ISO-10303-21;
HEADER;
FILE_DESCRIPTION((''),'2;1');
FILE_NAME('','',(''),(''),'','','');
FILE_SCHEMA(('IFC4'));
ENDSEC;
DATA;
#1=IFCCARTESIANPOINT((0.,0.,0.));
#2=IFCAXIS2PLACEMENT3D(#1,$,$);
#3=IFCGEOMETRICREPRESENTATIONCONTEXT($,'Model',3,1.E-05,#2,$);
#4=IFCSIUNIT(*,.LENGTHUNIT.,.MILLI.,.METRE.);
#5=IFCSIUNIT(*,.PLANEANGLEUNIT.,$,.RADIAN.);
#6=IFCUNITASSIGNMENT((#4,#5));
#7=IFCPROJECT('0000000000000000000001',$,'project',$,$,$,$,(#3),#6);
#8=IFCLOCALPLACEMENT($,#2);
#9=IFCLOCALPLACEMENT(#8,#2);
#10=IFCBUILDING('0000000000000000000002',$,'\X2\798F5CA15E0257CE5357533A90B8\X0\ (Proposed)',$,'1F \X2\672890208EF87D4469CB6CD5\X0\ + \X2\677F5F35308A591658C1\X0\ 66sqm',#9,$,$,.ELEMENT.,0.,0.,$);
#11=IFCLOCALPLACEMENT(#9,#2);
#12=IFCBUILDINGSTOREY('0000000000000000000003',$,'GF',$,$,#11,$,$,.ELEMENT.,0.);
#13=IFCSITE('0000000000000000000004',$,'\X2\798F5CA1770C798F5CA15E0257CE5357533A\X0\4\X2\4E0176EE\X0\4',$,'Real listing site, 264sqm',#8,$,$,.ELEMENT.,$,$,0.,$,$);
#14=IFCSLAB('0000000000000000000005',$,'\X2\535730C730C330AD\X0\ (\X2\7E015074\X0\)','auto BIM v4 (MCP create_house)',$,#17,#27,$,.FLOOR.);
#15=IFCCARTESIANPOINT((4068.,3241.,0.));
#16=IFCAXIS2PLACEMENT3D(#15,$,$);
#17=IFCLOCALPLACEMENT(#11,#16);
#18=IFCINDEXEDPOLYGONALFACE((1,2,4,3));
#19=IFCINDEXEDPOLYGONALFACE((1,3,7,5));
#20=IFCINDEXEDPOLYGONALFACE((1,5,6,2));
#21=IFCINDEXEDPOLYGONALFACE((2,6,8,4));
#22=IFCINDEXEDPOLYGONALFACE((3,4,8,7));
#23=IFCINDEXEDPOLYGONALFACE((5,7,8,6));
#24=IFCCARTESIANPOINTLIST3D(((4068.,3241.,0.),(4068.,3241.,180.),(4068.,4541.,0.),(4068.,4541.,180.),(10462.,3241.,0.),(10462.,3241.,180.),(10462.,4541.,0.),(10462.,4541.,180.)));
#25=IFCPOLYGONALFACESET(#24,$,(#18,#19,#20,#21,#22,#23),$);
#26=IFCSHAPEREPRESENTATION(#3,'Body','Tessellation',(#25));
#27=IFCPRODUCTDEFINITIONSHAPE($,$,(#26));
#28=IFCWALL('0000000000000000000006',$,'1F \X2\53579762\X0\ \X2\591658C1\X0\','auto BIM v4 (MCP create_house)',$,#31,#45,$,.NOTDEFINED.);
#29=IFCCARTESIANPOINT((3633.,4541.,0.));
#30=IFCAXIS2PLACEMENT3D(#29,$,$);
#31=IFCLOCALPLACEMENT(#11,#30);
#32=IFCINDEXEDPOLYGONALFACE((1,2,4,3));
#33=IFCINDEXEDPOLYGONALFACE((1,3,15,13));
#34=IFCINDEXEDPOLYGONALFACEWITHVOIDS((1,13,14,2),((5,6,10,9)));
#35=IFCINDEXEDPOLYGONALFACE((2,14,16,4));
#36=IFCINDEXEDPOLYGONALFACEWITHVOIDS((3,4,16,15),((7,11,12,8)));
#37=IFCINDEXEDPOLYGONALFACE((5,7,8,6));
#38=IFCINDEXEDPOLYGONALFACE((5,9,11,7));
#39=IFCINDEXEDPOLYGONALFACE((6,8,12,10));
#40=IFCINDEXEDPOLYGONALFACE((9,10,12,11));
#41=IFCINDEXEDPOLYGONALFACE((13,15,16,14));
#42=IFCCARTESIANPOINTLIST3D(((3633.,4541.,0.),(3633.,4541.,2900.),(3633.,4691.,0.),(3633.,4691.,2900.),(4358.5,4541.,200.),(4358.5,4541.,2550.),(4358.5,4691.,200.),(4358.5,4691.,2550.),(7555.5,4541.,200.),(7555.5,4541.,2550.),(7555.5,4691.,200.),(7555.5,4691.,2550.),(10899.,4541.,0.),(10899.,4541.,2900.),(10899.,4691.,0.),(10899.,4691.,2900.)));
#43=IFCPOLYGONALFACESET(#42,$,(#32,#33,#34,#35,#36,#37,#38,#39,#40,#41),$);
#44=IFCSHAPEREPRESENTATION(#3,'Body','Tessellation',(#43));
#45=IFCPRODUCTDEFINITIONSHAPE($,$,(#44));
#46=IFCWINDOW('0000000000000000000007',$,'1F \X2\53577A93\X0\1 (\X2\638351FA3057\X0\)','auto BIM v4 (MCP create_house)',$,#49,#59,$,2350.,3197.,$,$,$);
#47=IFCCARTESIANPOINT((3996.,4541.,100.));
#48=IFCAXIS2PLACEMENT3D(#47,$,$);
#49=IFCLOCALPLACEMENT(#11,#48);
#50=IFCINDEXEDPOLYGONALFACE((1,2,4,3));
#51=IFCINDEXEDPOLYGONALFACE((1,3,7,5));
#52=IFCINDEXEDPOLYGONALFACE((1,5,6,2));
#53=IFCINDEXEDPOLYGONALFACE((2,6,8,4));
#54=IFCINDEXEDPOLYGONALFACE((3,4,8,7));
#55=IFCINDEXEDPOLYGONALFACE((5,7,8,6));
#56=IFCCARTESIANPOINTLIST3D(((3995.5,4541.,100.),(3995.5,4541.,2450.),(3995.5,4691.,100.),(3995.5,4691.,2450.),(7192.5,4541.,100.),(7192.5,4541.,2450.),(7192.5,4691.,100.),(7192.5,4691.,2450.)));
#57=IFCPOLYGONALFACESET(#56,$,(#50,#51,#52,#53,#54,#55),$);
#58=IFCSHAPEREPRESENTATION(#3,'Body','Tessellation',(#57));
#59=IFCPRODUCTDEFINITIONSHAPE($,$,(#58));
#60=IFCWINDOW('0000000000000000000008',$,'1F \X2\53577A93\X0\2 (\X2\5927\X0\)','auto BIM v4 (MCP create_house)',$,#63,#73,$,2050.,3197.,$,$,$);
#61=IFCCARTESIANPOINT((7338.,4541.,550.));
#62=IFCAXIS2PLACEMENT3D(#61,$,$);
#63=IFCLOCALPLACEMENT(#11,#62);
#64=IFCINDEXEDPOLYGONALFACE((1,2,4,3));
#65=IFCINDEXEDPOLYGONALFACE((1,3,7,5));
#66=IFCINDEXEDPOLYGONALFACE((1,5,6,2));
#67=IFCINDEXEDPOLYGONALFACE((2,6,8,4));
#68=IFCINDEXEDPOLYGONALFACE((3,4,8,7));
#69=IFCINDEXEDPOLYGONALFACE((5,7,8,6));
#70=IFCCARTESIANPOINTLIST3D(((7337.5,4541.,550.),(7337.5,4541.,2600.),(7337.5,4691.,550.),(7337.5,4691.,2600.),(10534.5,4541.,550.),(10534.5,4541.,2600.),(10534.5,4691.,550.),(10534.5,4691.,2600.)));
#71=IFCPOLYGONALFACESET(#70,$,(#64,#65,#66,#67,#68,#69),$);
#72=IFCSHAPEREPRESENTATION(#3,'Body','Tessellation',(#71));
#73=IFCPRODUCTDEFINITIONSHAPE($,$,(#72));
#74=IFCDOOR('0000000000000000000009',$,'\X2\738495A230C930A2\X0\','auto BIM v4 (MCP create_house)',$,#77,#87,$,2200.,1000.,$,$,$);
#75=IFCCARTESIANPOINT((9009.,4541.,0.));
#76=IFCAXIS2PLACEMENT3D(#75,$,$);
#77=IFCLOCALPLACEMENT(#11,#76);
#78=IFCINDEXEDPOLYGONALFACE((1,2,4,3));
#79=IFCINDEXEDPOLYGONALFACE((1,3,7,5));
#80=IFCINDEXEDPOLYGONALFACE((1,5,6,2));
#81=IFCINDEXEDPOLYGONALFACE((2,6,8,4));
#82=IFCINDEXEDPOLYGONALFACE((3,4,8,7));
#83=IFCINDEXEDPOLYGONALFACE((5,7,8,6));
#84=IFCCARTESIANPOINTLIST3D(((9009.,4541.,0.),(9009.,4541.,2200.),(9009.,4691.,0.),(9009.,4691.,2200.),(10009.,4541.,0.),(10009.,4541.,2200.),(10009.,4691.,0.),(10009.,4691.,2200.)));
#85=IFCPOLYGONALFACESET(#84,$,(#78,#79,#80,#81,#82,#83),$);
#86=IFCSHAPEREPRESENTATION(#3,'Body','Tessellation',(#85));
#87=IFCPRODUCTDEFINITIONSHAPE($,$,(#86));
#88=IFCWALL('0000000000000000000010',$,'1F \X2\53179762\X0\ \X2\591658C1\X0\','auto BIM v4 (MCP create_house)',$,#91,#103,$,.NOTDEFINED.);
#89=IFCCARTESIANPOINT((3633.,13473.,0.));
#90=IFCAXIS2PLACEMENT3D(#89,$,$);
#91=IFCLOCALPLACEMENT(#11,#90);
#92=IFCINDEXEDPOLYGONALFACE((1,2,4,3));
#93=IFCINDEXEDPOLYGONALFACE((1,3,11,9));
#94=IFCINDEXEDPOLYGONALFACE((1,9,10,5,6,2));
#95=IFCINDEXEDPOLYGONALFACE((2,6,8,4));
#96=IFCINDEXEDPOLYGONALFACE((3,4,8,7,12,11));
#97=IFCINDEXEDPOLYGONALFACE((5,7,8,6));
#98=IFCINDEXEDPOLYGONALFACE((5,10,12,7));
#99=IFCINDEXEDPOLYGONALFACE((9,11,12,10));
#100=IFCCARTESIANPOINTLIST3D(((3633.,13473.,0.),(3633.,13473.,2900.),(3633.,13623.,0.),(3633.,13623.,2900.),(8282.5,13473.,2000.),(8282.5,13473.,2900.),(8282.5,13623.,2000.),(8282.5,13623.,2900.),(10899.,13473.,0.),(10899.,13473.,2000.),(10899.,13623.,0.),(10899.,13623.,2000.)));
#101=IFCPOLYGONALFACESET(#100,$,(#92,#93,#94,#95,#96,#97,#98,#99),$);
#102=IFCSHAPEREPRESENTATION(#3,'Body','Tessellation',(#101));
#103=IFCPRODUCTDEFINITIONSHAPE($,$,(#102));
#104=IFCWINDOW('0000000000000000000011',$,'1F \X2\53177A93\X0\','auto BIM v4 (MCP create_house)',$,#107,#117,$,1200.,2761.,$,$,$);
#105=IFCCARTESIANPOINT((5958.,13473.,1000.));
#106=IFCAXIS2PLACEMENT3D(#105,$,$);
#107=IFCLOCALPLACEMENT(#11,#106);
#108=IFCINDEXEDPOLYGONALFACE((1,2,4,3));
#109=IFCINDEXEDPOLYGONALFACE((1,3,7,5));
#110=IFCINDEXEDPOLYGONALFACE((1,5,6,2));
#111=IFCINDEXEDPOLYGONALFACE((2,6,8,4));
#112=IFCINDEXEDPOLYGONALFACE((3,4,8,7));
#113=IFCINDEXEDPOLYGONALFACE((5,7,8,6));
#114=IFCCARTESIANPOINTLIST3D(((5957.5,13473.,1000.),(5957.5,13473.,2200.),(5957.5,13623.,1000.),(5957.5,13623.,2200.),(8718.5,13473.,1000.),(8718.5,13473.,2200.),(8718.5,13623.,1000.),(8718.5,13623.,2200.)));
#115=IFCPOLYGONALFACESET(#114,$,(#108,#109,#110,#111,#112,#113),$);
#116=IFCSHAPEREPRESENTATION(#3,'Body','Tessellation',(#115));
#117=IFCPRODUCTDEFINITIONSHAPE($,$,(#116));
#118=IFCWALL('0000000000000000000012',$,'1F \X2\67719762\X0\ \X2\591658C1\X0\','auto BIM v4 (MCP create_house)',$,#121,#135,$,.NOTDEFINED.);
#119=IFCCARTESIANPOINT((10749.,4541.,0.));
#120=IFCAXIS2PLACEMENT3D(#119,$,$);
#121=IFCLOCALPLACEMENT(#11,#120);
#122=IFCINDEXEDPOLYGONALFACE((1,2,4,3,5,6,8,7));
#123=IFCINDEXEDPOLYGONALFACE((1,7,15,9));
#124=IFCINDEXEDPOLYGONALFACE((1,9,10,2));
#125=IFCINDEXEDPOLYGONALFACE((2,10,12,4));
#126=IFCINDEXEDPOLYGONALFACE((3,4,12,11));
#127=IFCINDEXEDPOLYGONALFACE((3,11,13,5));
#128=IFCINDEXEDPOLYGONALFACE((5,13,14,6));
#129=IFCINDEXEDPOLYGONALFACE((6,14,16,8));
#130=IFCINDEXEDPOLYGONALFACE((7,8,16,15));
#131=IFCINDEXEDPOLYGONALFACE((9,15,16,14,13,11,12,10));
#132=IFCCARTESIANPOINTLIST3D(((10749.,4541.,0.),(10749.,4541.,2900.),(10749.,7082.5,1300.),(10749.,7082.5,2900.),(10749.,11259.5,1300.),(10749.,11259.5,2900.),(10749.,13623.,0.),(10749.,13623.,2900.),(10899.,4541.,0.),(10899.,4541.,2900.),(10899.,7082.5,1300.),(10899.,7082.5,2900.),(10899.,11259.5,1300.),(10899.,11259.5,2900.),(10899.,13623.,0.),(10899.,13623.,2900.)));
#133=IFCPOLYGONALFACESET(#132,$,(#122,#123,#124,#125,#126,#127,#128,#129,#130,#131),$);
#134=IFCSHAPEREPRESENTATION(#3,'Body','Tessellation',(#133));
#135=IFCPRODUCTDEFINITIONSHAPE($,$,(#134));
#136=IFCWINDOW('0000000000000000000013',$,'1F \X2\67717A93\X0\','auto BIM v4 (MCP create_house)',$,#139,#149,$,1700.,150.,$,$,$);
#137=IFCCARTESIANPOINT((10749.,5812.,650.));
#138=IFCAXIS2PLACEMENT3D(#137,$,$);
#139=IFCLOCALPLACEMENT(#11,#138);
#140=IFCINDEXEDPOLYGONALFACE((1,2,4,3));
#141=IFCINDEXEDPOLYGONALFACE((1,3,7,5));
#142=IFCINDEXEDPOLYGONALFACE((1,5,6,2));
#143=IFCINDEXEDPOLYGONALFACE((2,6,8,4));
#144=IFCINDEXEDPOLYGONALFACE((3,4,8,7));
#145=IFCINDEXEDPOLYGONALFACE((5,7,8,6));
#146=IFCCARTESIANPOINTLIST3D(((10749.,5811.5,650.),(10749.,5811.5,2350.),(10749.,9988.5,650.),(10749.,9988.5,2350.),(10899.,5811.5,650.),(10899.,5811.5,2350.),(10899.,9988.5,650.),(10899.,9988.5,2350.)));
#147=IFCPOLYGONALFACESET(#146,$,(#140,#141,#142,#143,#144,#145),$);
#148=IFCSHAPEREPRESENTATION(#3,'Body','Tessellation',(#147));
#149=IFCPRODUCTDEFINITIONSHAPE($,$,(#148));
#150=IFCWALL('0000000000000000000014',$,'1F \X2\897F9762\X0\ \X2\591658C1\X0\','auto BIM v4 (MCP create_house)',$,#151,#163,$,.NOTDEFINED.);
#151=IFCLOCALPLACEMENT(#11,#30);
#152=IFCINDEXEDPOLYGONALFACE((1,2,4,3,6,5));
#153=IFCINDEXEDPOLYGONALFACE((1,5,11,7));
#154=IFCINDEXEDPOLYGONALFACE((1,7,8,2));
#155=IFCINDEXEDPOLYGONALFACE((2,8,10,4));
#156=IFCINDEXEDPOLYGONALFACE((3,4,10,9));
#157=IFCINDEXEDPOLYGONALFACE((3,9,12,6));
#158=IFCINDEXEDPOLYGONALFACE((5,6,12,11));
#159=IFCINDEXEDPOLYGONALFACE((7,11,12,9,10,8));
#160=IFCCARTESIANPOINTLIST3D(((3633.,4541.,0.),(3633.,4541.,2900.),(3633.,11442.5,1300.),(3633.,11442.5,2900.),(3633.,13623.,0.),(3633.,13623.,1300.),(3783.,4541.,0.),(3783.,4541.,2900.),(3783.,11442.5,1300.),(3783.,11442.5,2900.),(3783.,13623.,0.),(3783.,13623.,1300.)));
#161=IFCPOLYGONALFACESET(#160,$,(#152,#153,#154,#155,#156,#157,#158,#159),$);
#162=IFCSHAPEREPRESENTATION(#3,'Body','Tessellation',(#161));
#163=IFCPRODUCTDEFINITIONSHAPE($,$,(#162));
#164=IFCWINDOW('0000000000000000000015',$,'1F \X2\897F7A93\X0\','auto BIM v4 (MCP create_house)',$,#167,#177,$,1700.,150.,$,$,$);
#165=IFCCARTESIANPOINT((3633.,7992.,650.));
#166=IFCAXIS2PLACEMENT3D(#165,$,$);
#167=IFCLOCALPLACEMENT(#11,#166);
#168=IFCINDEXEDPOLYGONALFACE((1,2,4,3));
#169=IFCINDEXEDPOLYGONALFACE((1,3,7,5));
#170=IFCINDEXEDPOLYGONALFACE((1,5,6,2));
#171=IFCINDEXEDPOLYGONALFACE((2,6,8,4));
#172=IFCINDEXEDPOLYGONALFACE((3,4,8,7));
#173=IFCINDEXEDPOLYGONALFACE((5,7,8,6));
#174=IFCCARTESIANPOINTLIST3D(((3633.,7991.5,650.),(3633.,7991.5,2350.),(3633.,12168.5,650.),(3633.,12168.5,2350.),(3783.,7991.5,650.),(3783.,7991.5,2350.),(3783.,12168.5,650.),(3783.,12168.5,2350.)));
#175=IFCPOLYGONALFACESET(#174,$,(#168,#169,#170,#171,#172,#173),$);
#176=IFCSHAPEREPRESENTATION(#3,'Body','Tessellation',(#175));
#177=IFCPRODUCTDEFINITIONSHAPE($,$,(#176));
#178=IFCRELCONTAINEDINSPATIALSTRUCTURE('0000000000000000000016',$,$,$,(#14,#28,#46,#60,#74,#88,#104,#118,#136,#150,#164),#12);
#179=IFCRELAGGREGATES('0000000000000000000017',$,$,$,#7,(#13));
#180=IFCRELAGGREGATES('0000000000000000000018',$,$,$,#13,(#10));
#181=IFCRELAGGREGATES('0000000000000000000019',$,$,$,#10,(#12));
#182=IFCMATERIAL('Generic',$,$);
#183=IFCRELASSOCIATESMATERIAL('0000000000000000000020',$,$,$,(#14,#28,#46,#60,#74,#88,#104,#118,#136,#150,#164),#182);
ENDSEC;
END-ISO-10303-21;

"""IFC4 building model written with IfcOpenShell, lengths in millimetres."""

from ifc_helpers import new_model, si_unit, frame, frame_2d, origin, place, context, project, spatial, rectangle, extrude, material, element, fill, save


model = new_model("IFC4")

# Units and contexts
model_context = context("Model", 3, precision=1e-05, world=origin())
ifc_project = project(units=[si_unit("LENGTHUNIT", "METRE", prefix="MILLI"), si_unit("PLANEANGLEUNIT", "RADIAN")], contexts=[model_context])

# Site, building, storey
site_placement = place(None, origin())
site = spatial("IfcSite", under=ifc_project, at=site_placement, Name="福岡県福岡市城南区4丁目4", ObjectType="Real listing site, 264sqm", CompositionType="ELEMENT", RefElevation=0.0)
building_placement = place(site_placement, origin())
building = spatial("IfcBuilding", under=site, at=building_placement, Name="福岡市城南区邸 (Proposed)", ObjectType="1F 木造軸組構法 + 板張り外壁 66sqm", CompositionType="ELEMENT", ElevationOfRefHeight=0.0, ElevationOfTerrain=0.0)
storey_placement = place(building_placement, origin())
storey = spatial("IfcBuildingStorey", under=building, at=storey_placement, Name="GF", CompositionType="ELEMENT", Elevation=0.0)

# Slab
ifc_material = material(Name="Generic")
slab_1_placement = place(storey_placement, frame((4068.0, 3241.0, 0.0)))
element("IfcSlab", 1, at=slab_1_placement, inside=storey, material=ifc_material, Name="南デッキ (縁側)", Description="auto BIM v4 (MCP create_house)", PredefinedType="FLOOR", context=model_context, shape_type="SweptSolid", body=[
    extrude(rectangle(XDim=6394.0, YDim=1300.0, at=frame_2d((3197.0, 650.0))), frame((4068.0, 3241.0, 0.0)), (0.0, 0.0, 1.0), 180.0),
])

# Wall, openings, windows, door
wall_1_placement = place(storey_placement, frame((3633.0, 4541.0, 0.0)))
wall_1 = element("IfcWall", 2, at=wall_1_placement, inside=storey, material=ifc_material, Name="1F 南面 外壁", Description="auto BIM v4 (MCP create_house)", PredefinedType="NOTDEFINED", context=model_context, shape_type="SweptSolid", body=[
    extrude(rectangle(XDim=7266.0, YDim=150.0, at=frame_2d((3633.0, 75.0))), frame((3633.0, 4541.0, 0.0)), (0.0, 0.0, 1.0), 2900.0),
])
opening_1_placement = place(storey_placement, frame((3996.0, 4541.0, 100.0)))
opening_1 = element("IfcOpeningElement", 3, at=opening_1_placement, cuts=wall_1, PredefinedType="NOTDEFINED", context=model_context, shape_type="SweptSolid", body=[
    extrude(rectangle(XDim=3197.0, YDim=150.0, at=frame_2d((1598.0, 75.0))), frame((3996.0, 4541.0, 100.0)), (0.0, 0.0, 1.0), 2350.0),
])
opening_2_placement = place(storey_placement, frame((7338.0, 4541.0, 550.0)))
opening_2 = element("IfcOpeningElement", 4, at=opening_2_placement, cuts=wall_1, PredefinedType="NOTDEFINED", context=model_context, shape_type="SweptSolid", body=[
    extrude(rectangle(XDim=3197.0, YDim=150.0, at=frame_2d((1598.0, 75.0))), frame((7338.0, 4541.0, 550.0)), (0.0, 0.0, 1.0), 2050.0),
])
opening_3_placement = place(storey_placement, frame((9009.0, 4541.0, 0.0)))
opening_3 = element("IfcOpeningElement", 5, at=opening_3_placement, cuts=wall_1, PredefinedType="NOTDEFINED", context=model_context, shape_type="SweptSolid", body=[
    extrude(rectangle(XDim=1000.0, YDim=150.0, at=frame_2d((500.0, 75.0))), frame((9009.0, 4541.0, 0.0)), (0.0, 0.0, 1.0), 2200.0),
])
window_1_placement = place(storey_placement, frame((3996.0, 4541.0, 100.0)))
window_1 = element("IfcWindow", 6, at=window_1_placement, inside=storey, material=ifc_material, Name="1F 南窓1 (掃出し)", Description="auto BIM v4 (MCP create_house)", OverallHeight=2350.0, OverallWidth=3197.0, context=model_context, shape_type="SweptSolid", body=[
    extrude(rectangle(XDim=3197.0, YDim=150.0, at=frame_2d((1598.0, 75.0))), frame((3996.0, 4541.0, 100.0)), (0.0, 0.0, 1.0), 2350.0),
])
fill(opening_1, window_1)
window_2_placement = place(storey_placement, frame((7338.0, 4541.0, 550.0)))
window_2 = element("IfcWindow", 7, at=window_2_placement, inside=storey, material=ifc_material, Name="1F 南窓2 (大)", Description="auto BIM v4 (MCP create_house)", OverallHeight=2050.0, OverallWidth=3197.0, context=model_context, shape_type="SweptSolid", body=[
    extrude(rectangle(XDim=3197.0, YDim=150.0, at=frame_2d((1598.0, 75.0))), frame((7338.0, 4541.0, 550.0)), (0.0, 0.0, 1.0), 2050.0),
])
fill(opening_2, window_2)
door_placement = place(storey_placement, frame((9009.0, 4541.0, 0.0)))
door = element("IfcDoor", 8, at=door_placement, inside=storey, material=ifc_material, Name="玄関ドア", Description="auto BIM v4 (MCP create_house)", OverallHeight=2200.0, OverallWidth=1000.0, context=model_context, shape_type="SweptSolid", body=[
    extrude(rectangle(XDim=1000.0, YDim=150.0, at=frame_2d((500.0, 75.0))), frame((9009.0, 4541.0, 0.0)), (0.0, 0.0, 1.0), 2200.0),
])
fill(opening_3, door)

# Walls, openings, windows
wall_2_placement = place(storey_placement, frame((3633.0, 13473.0, 0.0)))
wall_2 = element("IfcWall", 9, at=wall_2_placement, inside=storey, material=ifc_material, Name="1F 北面 外壁", Description="auto BIM v4 (MCP create_house)", PredefinedType="NOTDEFINED", context=model_context, shape_type="SweptSolid", body=[
    extrude(rectangle(XDim=7266.0, YDim=150.0, at=frame_2d((3633.0, 75.0))), frame((3633.0, 13473.0, 0.0)), (0.0, 0.0, 1.0), 2900.0),
])
opening_4_placement = place(storey_placement, frame((5958.0, 13473.0, 1000.0)))
opening_4 = element("IfcOpeningElement", 10, at=opening_4_placement, cuts=wall_2, PredefinedType="NOTDEFINED", context=model_context, shape_type="SweptSolid", body=[
    extrude(rectangle(XDim=2761.0, YDim=150.0, at=frame_2d((1380.0, 75.0))), frame((5958.0, 13473.0, 1000.0)), (0.0, 0.0, 1.0), 1200.0),
])
window_3_placement = place(storey_placement, frame((5958.0, 13473.0, 1000.0)))
window_3 = element("IfcWindow", 11, at=window_3_placement, inside=storey, material=ifc_material, Name="1F 北窓", Description="auto BIM v4 (MCP create_house)", OverallHeight=1200.0, OverallWidth=2761.0, context=model_context, shape_type="SweptSolid", body=[
    extrude(rectangle(XDim=2761.0, YDim=150.0, at=frame_2d((1380.0, 75.0))), frame((5958.0, 13473.0, 1000.0)), (0.0, 0.0, 1.0), 1200.0),
])
fill(opening_4, window_3)
wall_3_placement = place(storey_placement, frame((10749.0, 4541.0, 0.0)))
wall_3 = element("IfcWall", 12, at=wall_3_placement, inside=storey, material=ifc_material, Name="1F 東面 外壁", Description="auto BIM v4 (MCP create_house)", PredefinedType="NOTDEFINED", context=model_context, shape_type="SweptSolid", body=[
    extrude(rectangle(XDim=150.0, YDim=9082.0, at=frame_2d((75.0, 4541.0))), frame((10749.0, 4541.0, 0.0)), (0.0, 0.0, 1.0), 2900.0),
])
opening_5_placement = place(storey_placement, frame((10749.0, 5812.0, 650.0)))
opening_5 = element("IfcOpeningElement", 13, at=opening_5_placement, cuts=wall_3, PredefinedType="NOTDEFINED", context=model_context, shape_type="SweptSolid", body=[
    extrude(rectangle(XDim=150.0, YDim=4177.0, at=frame_2d((75.0, 2088.0))), frame((10749.0, 5812.0, 650.0)), (0.0, 0.0, 1.0), 1700.0),
])
window_4_placement = place(storey_placement, frame((10749.0, 5812.0, 650.0)))
window_4 = element("IfcWindow", 14, at=window_4_placement, inside=storey, material=ifc_material, Name="1F 東窓", Description="auto BIM v4 (MCP create_house)", OverallHeight=1700.0, OverallWidth=150.0, context=model_context, shape_type="SweptSolid", body=[
    extrude(rectangle(XDim=150.0, YDim=4177.0, at=frame_2d((75.0, 2088.0))), frame((10749.0, 5812.0, 650.0)), (0.0, 0.0, 1.0), 1700.0),
])
fill(opening_5, window_4)
wall_4_placement = place(storey_placement, frame((3633.0, 4541.0, 0.0)))
wall_4 = element("IfcWall", 15, at=wall_4_placement, inside=storey, material=ifc_material, Name="1F 西面 外壁", Description="auto BIM v4 (MCP create_house)", PredefinedType="NOTDEFINED", context=model_context, shape_type="SweptSolid", body=[
    extrude(rectangle(XDim=150.0, YDim=9082.0, at=frame_2d((75.0, 4541.0))), frame((3633.0, 4541.0, 0.0)), (0.0, 0.0, 1.0), 2900.0),
])
opening_6_placement = place(storey_placement, frame((3633.0, 7992.0, 650.0)))
opening_6 = element("IfcOpeningElement", 16, at=opening_6_placement, cuts=wall_4, PredefinedType="NOTDEFINED", context=model_context, shape_type="SweptSolid", body=[
    extrude(rectangle(XDim=150.0, YDim=4177.0, at=frame_2d((75.0, 2088.0))), frame((3633.0, 7992.0, 650.0)), (0.0, 0.0, 1.0), 1700.0),
])
window_5_placement = place(storey_placement, frame((3633.0, 7992.0, 650.0)))
window_5 = element("IfcWindow", 17, at=window_5_placement, inside=storey, material=ifc_material, Name="1F 西窓", Description="auto BIM v4 (MCP create_house)", OverallHeight=1700.0, OverallWidth=150.0, context=model_context, shape_type="SweptSolid", body=[
    extrude(rectangle(XDim=150.0, YDim=4177.0, at=frame_2d((75.0, 2088.0))), frame((3633.0, 7992.0, 650.0)), (0.0, 0.0, 1.0), 1700.0),
])
fill(opening_6, window_5)

save(model, "model.ifc")
